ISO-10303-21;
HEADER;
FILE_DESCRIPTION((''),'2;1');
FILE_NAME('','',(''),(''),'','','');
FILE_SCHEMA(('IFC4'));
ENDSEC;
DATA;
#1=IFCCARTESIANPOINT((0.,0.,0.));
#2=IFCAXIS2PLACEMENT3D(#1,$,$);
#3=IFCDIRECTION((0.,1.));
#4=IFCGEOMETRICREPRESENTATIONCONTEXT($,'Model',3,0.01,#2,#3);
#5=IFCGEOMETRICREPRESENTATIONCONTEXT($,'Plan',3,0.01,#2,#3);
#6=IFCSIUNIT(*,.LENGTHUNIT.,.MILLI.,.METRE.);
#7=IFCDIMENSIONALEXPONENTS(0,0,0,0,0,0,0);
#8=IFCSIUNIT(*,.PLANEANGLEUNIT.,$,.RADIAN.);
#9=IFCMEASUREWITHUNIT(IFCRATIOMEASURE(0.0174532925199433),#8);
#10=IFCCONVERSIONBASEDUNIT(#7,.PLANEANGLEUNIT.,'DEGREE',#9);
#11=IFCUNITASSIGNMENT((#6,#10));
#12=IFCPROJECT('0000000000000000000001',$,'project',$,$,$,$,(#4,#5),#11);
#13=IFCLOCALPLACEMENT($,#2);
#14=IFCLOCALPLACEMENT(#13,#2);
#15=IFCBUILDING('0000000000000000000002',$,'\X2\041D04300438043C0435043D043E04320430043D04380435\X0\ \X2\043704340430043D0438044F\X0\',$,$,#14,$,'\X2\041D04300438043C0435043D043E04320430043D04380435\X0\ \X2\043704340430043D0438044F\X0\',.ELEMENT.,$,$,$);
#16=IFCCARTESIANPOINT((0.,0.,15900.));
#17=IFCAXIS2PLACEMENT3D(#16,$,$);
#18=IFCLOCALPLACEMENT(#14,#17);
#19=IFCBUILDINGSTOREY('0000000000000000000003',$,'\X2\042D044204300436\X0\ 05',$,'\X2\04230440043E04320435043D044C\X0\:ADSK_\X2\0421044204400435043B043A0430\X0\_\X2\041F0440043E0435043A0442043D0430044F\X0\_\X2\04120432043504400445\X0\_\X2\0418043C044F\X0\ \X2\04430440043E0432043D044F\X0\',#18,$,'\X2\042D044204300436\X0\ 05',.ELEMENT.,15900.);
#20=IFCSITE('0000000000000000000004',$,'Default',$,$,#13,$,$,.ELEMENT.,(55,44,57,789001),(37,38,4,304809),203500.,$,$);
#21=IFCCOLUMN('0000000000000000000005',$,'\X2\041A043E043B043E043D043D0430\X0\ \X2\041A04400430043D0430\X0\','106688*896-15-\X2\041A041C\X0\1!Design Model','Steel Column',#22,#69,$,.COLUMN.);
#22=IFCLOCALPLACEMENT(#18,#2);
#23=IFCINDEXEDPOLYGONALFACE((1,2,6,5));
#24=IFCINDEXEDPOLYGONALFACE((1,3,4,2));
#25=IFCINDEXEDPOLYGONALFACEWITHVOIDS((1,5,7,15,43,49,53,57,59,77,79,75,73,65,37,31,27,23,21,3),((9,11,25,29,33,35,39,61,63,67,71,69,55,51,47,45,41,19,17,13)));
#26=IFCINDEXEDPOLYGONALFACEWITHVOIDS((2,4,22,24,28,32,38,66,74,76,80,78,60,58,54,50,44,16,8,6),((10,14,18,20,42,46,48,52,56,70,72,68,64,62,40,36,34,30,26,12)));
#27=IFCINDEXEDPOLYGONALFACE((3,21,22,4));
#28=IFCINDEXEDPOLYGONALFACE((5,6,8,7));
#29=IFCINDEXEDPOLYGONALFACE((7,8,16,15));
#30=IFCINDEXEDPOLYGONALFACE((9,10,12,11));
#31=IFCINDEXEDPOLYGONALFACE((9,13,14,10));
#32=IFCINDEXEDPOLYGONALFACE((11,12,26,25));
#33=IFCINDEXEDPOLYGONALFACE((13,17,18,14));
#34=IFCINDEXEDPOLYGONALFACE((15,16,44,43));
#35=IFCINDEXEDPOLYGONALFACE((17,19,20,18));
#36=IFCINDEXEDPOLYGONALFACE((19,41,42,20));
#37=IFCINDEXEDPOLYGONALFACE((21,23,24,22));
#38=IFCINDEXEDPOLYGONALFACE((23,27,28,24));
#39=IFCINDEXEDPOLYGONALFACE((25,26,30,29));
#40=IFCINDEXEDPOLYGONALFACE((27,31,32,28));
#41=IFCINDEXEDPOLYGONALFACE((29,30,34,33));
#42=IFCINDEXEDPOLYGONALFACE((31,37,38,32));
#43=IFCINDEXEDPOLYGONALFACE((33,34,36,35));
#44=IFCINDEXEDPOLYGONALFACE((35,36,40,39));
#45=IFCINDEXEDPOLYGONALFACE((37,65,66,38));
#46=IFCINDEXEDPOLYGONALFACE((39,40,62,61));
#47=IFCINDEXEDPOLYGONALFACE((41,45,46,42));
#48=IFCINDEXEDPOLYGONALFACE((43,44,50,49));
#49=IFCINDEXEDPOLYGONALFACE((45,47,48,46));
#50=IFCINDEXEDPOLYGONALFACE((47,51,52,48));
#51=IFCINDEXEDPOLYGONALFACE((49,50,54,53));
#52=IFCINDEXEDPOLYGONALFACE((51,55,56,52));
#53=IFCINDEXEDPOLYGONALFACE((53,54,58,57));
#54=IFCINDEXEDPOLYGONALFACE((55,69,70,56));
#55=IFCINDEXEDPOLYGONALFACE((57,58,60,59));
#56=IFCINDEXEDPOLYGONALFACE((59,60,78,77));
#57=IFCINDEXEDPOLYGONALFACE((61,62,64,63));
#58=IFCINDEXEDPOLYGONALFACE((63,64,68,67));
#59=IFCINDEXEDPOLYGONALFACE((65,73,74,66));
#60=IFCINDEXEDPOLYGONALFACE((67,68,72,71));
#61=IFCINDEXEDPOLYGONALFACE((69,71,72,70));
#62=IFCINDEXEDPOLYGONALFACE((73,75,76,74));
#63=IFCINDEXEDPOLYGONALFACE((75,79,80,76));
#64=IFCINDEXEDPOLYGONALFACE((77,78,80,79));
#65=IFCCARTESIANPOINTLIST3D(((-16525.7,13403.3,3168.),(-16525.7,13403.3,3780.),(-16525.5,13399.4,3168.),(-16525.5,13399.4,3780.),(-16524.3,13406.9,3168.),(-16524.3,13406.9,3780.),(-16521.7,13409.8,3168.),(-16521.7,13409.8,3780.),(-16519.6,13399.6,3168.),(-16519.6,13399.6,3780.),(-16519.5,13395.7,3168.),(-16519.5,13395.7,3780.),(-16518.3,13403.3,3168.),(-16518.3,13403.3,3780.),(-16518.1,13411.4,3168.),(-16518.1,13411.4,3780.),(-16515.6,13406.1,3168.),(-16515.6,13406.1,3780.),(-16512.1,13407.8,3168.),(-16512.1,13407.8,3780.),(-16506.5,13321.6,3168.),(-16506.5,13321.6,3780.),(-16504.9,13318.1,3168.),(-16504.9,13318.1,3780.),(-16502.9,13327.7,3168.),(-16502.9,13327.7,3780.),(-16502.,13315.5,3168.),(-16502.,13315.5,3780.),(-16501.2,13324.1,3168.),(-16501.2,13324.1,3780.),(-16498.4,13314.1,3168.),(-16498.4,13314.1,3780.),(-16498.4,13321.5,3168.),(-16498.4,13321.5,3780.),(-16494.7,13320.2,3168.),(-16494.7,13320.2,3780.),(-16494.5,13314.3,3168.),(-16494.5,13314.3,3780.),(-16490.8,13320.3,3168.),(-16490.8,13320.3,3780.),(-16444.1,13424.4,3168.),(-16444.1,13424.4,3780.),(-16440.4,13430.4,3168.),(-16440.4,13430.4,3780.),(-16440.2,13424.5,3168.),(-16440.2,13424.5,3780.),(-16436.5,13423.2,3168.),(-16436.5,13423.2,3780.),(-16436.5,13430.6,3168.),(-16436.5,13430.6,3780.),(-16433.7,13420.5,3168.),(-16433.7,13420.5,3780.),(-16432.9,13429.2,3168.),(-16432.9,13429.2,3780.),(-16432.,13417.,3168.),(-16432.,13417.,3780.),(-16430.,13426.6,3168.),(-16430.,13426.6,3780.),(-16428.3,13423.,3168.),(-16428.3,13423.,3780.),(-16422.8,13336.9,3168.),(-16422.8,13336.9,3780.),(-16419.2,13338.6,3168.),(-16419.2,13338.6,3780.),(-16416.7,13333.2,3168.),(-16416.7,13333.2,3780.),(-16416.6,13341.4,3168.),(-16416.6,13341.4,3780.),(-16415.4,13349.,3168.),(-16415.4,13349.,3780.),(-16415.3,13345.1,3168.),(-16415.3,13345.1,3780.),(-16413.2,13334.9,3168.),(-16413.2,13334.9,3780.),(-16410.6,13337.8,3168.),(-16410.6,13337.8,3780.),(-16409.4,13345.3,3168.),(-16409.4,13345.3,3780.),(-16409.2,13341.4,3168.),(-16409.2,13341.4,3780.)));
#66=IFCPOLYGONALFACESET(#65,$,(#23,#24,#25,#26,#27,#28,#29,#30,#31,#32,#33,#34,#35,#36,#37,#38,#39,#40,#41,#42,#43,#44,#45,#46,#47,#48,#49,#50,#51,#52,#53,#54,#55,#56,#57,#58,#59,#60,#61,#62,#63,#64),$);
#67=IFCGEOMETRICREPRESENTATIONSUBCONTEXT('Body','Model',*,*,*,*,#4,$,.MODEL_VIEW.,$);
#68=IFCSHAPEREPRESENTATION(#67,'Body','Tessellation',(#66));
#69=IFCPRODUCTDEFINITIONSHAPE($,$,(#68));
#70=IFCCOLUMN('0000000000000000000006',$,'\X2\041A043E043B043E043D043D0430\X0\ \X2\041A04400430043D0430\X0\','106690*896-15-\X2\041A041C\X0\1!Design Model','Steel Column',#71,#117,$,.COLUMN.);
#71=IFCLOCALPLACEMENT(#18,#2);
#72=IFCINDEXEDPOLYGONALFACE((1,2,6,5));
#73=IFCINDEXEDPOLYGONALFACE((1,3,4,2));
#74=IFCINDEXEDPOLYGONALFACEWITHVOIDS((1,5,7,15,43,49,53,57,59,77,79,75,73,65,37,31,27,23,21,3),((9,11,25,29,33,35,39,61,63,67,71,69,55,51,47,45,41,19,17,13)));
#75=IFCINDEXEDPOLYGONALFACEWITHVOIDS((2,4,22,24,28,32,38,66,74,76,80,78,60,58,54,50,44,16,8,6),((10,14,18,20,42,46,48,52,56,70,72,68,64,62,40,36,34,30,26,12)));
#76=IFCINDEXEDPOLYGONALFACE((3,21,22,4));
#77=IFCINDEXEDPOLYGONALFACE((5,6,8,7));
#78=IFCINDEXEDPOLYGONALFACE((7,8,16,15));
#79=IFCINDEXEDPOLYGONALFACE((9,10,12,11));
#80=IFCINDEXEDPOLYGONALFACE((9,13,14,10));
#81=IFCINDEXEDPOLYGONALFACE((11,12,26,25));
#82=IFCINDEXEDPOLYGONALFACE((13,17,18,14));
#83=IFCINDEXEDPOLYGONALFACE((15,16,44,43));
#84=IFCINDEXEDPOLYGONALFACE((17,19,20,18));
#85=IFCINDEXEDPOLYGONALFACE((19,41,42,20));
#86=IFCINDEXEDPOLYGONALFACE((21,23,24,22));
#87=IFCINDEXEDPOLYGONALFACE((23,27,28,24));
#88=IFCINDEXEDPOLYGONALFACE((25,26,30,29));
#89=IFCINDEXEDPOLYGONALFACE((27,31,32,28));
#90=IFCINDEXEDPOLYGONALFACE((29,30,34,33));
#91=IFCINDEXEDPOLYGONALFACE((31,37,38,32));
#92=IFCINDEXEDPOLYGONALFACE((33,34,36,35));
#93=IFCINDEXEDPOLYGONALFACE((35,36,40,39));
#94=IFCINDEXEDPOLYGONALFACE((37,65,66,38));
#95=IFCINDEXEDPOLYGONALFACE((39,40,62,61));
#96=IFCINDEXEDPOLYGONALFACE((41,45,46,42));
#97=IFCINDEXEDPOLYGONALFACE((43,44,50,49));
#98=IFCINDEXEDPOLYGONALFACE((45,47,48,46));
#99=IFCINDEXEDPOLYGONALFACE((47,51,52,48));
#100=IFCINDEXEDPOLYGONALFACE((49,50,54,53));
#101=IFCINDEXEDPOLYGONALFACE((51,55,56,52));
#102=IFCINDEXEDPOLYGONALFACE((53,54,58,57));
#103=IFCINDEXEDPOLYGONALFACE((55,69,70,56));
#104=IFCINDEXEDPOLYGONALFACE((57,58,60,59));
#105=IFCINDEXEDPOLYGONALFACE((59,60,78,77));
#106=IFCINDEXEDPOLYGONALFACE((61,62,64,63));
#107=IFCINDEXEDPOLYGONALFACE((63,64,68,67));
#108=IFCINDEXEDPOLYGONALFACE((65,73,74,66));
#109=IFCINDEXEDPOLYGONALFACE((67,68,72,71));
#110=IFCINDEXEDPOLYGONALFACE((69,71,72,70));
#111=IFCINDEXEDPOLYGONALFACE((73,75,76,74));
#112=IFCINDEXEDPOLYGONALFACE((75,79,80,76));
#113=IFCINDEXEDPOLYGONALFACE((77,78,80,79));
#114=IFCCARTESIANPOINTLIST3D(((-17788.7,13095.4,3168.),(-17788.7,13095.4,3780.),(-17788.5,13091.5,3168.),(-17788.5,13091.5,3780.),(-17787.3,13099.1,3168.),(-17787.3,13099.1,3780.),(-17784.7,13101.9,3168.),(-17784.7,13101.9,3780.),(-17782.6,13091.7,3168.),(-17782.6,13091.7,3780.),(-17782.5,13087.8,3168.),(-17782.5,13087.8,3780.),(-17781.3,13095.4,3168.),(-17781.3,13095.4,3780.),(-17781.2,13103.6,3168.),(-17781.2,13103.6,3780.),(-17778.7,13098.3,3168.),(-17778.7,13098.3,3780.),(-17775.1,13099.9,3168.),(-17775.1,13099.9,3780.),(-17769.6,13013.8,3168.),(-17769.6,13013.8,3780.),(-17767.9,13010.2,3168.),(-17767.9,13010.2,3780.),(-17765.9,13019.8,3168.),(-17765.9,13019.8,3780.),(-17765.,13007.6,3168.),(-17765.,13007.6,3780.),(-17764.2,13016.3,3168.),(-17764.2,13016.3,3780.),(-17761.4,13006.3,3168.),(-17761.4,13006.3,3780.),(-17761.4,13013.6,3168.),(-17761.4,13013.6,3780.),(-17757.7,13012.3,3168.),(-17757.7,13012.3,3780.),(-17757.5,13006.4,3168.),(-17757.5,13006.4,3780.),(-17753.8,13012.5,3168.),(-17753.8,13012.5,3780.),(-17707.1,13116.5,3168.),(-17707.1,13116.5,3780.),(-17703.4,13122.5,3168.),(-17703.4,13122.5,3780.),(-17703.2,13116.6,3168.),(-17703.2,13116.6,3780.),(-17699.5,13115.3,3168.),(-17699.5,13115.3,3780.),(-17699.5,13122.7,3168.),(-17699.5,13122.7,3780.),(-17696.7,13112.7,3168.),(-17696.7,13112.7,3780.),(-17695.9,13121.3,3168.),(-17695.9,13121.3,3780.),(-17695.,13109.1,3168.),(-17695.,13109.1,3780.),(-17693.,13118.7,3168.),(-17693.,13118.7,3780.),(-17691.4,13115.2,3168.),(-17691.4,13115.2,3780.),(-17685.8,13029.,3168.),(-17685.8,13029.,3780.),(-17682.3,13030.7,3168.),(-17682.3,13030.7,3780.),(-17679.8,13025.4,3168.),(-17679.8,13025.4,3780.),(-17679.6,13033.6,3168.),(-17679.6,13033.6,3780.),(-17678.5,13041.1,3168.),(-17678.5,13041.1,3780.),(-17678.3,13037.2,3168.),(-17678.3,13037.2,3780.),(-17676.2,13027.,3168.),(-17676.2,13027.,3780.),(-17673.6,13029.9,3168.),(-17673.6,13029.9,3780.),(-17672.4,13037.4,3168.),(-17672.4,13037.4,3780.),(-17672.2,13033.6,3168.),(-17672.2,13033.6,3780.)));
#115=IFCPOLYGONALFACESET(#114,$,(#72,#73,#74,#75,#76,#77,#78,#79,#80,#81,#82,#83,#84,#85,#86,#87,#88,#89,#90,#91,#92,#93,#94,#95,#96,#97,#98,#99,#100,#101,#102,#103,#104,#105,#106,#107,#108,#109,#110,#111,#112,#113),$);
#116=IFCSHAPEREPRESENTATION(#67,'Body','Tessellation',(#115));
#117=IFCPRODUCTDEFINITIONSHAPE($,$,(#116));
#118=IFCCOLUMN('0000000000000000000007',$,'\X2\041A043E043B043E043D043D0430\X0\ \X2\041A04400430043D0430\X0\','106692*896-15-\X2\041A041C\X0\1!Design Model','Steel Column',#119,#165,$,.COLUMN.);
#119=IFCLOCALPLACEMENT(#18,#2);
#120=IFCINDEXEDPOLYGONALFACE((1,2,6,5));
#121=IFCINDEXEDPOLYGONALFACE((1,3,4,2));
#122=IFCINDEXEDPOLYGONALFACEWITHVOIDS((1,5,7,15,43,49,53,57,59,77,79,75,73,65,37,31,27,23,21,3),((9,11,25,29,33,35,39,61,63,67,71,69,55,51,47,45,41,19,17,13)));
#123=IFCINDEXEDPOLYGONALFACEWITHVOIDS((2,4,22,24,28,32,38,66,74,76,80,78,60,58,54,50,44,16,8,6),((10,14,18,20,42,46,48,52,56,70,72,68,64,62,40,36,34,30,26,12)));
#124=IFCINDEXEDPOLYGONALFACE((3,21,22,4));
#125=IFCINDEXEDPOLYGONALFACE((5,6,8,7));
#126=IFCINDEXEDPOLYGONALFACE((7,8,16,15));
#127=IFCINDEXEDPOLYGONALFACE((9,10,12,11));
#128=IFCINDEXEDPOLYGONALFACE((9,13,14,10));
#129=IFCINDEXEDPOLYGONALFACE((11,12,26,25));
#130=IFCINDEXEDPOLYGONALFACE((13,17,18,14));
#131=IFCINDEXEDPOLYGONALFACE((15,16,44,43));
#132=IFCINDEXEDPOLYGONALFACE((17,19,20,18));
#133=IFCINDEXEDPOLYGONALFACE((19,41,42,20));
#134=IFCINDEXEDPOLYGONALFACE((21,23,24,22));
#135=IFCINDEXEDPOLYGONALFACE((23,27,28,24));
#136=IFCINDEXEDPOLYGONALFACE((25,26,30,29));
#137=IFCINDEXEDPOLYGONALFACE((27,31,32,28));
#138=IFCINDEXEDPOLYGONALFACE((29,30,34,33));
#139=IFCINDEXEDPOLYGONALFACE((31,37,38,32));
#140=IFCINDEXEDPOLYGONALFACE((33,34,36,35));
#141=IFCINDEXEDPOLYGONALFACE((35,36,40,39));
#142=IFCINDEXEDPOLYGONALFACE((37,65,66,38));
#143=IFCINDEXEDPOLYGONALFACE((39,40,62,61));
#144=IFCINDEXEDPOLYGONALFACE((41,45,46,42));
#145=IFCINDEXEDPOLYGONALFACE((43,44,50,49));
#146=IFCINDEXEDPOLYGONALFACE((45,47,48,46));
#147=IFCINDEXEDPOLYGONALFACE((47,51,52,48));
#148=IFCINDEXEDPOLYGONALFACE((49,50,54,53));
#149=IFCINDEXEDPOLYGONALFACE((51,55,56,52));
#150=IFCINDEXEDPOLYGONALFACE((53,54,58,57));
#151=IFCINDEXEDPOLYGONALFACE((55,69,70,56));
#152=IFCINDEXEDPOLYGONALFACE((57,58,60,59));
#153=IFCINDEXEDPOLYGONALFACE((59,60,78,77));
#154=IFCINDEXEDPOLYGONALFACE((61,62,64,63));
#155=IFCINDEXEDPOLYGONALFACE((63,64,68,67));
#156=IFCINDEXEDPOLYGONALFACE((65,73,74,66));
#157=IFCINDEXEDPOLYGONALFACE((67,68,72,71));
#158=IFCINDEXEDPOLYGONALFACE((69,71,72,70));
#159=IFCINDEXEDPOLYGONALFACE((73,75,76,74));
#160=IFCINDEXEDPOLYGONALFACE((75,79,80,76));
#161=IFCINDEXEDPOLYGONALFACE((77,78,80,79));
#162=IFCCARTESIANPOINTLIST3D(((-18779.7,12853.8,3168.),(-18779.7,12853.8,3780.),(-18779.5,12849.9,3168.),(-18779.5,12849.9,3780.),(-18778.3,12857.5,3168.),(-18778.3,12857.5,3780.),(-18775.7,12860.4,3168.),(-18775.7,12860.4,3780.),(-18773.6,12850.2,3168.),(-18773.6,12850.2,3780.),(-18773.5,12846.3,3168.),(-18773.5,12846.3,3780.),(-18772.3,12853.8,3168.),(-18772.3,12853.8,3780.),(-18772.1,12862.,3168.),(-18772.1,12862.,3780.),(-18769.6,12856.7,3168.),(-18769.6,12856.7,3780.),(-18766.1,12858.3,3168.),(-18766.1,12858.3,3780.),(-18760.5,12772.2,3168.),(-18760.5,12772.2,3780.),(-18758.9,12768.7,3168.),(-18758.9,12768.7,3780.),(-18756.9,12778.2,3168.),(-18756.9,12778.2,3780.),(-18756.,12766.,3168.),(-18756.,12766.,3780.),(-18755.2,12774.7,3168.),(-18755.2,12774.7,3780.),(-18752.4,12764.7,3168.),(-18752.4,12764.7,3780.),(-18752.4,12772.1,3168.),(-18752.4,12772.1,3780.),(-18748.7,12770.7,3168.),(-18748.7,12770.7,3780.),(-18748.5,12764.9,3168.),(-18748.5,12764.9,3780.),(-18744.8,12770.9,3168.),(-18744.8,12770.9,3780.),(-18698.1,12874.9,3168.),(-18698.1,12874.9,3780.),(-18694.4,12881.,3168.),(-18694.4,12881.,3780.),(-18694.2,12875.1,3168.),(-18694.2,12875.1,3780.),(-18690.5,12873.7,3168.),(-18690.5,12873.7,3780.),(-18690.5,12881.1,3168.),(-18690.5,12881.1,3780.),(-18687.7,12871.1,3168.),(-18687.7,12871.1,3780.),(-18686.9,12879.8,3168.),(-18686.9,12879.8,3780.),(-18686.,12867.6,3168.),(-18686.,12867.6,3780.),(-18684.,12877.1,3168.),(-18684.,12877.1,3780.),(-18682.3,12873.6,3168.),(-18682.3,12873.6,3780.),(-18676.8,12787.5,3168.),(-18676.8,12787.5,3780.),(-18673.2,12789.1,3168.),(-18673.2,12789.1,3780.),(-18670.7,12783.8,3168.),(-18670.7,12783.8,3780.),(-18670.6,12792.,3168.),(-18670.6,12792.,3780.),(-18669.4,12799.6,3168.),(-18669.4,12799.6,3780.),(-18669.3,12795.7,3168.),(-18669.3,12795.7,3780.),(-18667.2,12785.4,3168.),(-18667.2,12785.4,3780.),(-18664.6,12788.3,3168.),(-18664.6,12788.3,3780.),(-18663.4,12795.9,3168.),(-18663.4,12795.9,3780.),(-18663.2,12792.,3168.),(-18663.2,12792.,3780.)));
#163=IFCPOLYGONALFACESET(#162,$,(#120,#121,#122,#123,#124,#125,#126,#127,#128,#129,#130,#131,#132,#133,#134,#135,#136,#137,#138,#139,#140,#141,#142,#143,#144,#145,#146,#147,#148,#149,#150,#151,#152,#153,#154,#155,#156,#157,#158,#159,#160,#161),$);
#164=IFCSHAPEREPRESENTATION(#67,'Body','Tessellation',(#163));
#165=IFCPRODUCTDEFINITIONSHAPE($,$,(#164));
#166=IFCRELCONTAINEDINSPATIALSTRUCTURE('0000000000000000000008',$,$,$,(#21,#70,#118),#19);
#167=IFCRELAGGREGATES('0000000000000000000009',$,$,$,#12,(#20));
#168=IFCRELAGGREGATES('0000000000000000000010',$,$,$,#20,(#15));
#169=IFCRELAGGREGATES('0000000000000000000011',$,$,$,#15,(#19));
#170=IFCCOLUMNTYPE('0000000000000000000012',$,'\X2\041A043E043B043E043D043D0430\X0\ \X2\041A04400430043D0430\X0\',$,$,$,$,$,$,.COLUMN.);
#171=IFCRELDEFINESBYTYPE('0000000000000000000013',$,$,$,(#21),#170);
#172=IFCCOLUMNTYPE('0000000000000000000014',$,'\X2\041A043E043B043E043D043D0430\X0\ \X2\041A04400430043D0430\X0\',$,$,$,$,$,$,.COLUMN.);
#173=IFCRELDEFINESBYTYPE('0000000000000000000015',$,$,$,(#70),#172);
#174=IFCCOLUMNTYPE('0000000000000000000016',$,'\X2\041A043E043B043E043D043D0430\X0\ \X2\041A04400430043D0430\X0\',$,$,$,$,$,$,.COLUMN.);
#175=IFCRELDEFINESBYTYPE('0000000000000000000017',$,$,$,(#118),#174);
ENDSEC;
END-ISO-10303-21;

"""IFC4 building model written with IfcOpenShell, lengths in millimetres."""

from ifc_helpers import new_model, entity, si_unit, converted_unit, direction, frame, origin, place, context, subcontext, project, spatial, indexed_curve, outline, extrude, type_object, element, save


model = new_model("IFC4")

# Units and contexts
model_context = context("Model", 3, precision=0.01, world=origin(), true_north=direction((0.0, 1.0)))
plan_context = context("Plan", 3, precision=0.01, world=origin(), true_north=direction((0.0, 1.0)))
body_context = subcontext(model_context, "Body", "Model", "MODEL_VIEW")
ifc_project = project(units=[si_unit("LENGTHUNIT", "METRE", prefix="MILLI"), converted_unit("PLANEANGLEUNIT", "DEGREE", entity("IfcRatioMeasure", 0.0174532925199433), si_unit("PLANEANGLEUNIT", "RADIAN"), dimensions=[0, 0, 0, 0, 0, 0, 0])], contexts=[model_context, plan_context])

# Site, building, storey
site_placement = place(None, origin())
site = spatial("IfcSite", under=ifc_project, at=site_placement, Name="Default", CompositionType="ELEMENT", RefLatitude=(55, 44, 57, 789001), RefLongitude=(37, 38, 4, 304809), RefElevation=203500.0)
building_placement = place(site_placement, origin())
building = spatial("IfcBuilding", under=site, at=building_placement, Name="Наименование здания", LongName="Наименование здания", CompositionType="ELEMENT")
storey_placement = place(building_placement, frame((0.0, 0.0, 15900.0)))
storey = spatial("IfcBuildingStorey", under=building, at=storey_placement, Name="Этаж 05", ObjectType="Уровень:ADSK_Стрелка_Проектная_Вверх_Имя уровня", LongName="Этаж 05", CompositionType="ELEMENT", Elevation=15900.0)

# Columns
column_type_1 = type_object("IfcColumnType", Name="Колонна Крана", PredefinedType="COLUMN")
column_1_placement = place(storey_placement, origin())
element("IfcColumn", 1, at=column_1_placement, inside=storey, type_object=column_type_1, Name="Колонна Крана", Description="106688*896-15-КМ1!Design Model", ObjectType="Steel Column", PredefinedType="COLUMN", context=body_context, shape_type="SweptSolid", body=[
    extrude(outline(indexed_curve([(29.5, -56.8), (33.4, -56.8), (37.0, -55.3), (39.7, -52.6), (41.2, -49.0), (56.8, 29.5), (56.8, 33.4), (55.3, 37.0), (52.6, 39.7), (49.0, 41.2), (-29.5, 56.8), (-33.4, 56.8), (-37.0, 55.3), (-39.7, 52.6), (-41.2, 49.0), (-56.8, -29.5), (-56.8, -33.4), (-55.3, -37.0), (-52.6, -39.7), (-49.0, -41.2), (29.5, -56.8)], self_intersect=False), holes=[indexed_curve([(-43.1, -37.3), (-46.7, -35.8), (-49.5, -33.1), (-51.0, -29.5), (-51.0, -25.5), (-37.3, 43.1), (-35.8, 46.7), (-33.1, 49.5), (-29.5, 51.0), (-25.5, 51.0), (43.1, 37.3), (46.7, 35.8), (49.5, 33.1), (51.0, 29.5), (51.0, 25.5), (37.3, -43.1), (35.8, -46.7), (33.1, -49.5), (29.5, -51.0), (25.5, -51.0), (-43.1, -37.3)], self_intersect=False)]), frame((-16467.4, 13372.3, 3168.0), z_axis=(0.0, 0.0, 1.0), x_axis=(-0.906681, -0.421816, 0.0)), (0.0, 0.0, 1.0), 612.0),
])
column_type_2 = type_object("IfcColumnType", Name="Колонна Крана", PredefinedType="COLUMN")
column_2_placement = place(storey_placement, origin())
element("IfcColumn", 2, at=column_2_placement, inside=storey, type_object=column_type_2, Name="Колонна Крана", Description="106690*896-15-КМ1!Design Model", ObjectType="Steel Column", PredefinedType="COLUMN", context=body_context, shape_type="SweptSolid", body=[
    extrude(outline(indexed_curve([(29.5, -56.8), (33.4, -56.8), (37.0, -55.3), (39.7, -52.6), (41.2, -49.0), (56.8, 29.5), (56.8, 33.4), (55.3, 37.0), (52.6, 39.7), (49.0, 41.2), (-29.5, 56.8), (-33.4, 56.8), (-37.0, 55.3), (-39.7, 52.6), (-41.2, 49.0), (-56.8, -29.5), (-56.8, -33.4), (-55.3, -37.0), (-52.6, -39.7), (-49.0, -41.2), (29.5, -56.8)], self_intersect=False), holes=[indexed_curve([(-43.1, -37.3), (-46.7, -35.8), (-49.5, -33.1), (-51.0, -29.5), (-51.0, -25.5), (-37.3, 43.1), (-35.8, 46.7), (-33.1, 49.5), (-29.5, 51.0), (-25.5, 51.0), (43.1, 37.3), (46.7, 35.8), (49.5, 33.1), (51.0, 29.5), (51.0, 25.5), (37.3, -43.1), (35.8, -46.7), (33.1, -49.5), (29.5, -51.0), (25.5, -51.0), (-43.1, -37.3)], self_intersect=False)]), frame((-17730.5, 13064.5, 3168.0), z_axis=(0.0, 0.0, 1.0), x_axis=(-0.906681, -0.421816, 0.0)), (0.0, 0.0, 1.0), 612.0),
])
column_type_3 = type_object("IfcColumnType", Name="Колонна Крана", PredefinedType="COLUMN")
column_3_placement = place(storey_placement, origin())
element("IfcColumn", 3, at=column_3_placement, inside=storey, type_object=column_type_3, Name="Колонна Крана", Description="106692*896-15-КМ1!Design Model", ObjectType="Steel Column", PredefinedType="COLUMN", context=body_context, shape_type="SweptSolid", body=[
    extrude(outline(indexed_curve([(29.5, -56.8), (33.4, -56.8), (37.0, -55.3), (39.7, -52.6), (41.2, -49.0), (56.8, 29.5), (56.8, 33.4), (55.3, 37.0), (52.6, 39.7), (49.0, 41.2), (-29.5, 56.8), (-33.4, 56.8), (-37.0, 55.3), (-39.7, 52.6), (-41.2, 49.0), (-56.8, -29.5), (-56.8, -33.4), (-55.3, -37.0), (-52.6, -39.7), (-49.0, -41.2), (29.5, -56.8)], self_intersect=False), holes=[indexed_curve([(-43.1, -37.3), (-46.7, -35.8), (-49.5, -33.1), (-51.0, -29.5), (-51.0, -25.5), (-37.3, 43.1), (-35.8, 46.7), (-33.1, 49.5), (-29.5, 51.0), (-25.5, 51.0), (43.1, 37.3), (46.7, 35.8), (49.5, 33.1), (51.0, 29.5), (51.0, 25.5), (37.3, -43.1), (35.8, -46.7), (33.1, -49.5), (29.5, -51.0), (25.5, -51.0), (-43.1, -37.3)], self_intersect=False)]), frame((-18721.4, 12822.9, 3168.0), z_axis=(0.0, 0.0, 1.0), x_axis=(-0.906681, -0.421816, 0.0)), (0.0, 0.0, 1.0), 612.0),
])

save(model, "model.ifc")
